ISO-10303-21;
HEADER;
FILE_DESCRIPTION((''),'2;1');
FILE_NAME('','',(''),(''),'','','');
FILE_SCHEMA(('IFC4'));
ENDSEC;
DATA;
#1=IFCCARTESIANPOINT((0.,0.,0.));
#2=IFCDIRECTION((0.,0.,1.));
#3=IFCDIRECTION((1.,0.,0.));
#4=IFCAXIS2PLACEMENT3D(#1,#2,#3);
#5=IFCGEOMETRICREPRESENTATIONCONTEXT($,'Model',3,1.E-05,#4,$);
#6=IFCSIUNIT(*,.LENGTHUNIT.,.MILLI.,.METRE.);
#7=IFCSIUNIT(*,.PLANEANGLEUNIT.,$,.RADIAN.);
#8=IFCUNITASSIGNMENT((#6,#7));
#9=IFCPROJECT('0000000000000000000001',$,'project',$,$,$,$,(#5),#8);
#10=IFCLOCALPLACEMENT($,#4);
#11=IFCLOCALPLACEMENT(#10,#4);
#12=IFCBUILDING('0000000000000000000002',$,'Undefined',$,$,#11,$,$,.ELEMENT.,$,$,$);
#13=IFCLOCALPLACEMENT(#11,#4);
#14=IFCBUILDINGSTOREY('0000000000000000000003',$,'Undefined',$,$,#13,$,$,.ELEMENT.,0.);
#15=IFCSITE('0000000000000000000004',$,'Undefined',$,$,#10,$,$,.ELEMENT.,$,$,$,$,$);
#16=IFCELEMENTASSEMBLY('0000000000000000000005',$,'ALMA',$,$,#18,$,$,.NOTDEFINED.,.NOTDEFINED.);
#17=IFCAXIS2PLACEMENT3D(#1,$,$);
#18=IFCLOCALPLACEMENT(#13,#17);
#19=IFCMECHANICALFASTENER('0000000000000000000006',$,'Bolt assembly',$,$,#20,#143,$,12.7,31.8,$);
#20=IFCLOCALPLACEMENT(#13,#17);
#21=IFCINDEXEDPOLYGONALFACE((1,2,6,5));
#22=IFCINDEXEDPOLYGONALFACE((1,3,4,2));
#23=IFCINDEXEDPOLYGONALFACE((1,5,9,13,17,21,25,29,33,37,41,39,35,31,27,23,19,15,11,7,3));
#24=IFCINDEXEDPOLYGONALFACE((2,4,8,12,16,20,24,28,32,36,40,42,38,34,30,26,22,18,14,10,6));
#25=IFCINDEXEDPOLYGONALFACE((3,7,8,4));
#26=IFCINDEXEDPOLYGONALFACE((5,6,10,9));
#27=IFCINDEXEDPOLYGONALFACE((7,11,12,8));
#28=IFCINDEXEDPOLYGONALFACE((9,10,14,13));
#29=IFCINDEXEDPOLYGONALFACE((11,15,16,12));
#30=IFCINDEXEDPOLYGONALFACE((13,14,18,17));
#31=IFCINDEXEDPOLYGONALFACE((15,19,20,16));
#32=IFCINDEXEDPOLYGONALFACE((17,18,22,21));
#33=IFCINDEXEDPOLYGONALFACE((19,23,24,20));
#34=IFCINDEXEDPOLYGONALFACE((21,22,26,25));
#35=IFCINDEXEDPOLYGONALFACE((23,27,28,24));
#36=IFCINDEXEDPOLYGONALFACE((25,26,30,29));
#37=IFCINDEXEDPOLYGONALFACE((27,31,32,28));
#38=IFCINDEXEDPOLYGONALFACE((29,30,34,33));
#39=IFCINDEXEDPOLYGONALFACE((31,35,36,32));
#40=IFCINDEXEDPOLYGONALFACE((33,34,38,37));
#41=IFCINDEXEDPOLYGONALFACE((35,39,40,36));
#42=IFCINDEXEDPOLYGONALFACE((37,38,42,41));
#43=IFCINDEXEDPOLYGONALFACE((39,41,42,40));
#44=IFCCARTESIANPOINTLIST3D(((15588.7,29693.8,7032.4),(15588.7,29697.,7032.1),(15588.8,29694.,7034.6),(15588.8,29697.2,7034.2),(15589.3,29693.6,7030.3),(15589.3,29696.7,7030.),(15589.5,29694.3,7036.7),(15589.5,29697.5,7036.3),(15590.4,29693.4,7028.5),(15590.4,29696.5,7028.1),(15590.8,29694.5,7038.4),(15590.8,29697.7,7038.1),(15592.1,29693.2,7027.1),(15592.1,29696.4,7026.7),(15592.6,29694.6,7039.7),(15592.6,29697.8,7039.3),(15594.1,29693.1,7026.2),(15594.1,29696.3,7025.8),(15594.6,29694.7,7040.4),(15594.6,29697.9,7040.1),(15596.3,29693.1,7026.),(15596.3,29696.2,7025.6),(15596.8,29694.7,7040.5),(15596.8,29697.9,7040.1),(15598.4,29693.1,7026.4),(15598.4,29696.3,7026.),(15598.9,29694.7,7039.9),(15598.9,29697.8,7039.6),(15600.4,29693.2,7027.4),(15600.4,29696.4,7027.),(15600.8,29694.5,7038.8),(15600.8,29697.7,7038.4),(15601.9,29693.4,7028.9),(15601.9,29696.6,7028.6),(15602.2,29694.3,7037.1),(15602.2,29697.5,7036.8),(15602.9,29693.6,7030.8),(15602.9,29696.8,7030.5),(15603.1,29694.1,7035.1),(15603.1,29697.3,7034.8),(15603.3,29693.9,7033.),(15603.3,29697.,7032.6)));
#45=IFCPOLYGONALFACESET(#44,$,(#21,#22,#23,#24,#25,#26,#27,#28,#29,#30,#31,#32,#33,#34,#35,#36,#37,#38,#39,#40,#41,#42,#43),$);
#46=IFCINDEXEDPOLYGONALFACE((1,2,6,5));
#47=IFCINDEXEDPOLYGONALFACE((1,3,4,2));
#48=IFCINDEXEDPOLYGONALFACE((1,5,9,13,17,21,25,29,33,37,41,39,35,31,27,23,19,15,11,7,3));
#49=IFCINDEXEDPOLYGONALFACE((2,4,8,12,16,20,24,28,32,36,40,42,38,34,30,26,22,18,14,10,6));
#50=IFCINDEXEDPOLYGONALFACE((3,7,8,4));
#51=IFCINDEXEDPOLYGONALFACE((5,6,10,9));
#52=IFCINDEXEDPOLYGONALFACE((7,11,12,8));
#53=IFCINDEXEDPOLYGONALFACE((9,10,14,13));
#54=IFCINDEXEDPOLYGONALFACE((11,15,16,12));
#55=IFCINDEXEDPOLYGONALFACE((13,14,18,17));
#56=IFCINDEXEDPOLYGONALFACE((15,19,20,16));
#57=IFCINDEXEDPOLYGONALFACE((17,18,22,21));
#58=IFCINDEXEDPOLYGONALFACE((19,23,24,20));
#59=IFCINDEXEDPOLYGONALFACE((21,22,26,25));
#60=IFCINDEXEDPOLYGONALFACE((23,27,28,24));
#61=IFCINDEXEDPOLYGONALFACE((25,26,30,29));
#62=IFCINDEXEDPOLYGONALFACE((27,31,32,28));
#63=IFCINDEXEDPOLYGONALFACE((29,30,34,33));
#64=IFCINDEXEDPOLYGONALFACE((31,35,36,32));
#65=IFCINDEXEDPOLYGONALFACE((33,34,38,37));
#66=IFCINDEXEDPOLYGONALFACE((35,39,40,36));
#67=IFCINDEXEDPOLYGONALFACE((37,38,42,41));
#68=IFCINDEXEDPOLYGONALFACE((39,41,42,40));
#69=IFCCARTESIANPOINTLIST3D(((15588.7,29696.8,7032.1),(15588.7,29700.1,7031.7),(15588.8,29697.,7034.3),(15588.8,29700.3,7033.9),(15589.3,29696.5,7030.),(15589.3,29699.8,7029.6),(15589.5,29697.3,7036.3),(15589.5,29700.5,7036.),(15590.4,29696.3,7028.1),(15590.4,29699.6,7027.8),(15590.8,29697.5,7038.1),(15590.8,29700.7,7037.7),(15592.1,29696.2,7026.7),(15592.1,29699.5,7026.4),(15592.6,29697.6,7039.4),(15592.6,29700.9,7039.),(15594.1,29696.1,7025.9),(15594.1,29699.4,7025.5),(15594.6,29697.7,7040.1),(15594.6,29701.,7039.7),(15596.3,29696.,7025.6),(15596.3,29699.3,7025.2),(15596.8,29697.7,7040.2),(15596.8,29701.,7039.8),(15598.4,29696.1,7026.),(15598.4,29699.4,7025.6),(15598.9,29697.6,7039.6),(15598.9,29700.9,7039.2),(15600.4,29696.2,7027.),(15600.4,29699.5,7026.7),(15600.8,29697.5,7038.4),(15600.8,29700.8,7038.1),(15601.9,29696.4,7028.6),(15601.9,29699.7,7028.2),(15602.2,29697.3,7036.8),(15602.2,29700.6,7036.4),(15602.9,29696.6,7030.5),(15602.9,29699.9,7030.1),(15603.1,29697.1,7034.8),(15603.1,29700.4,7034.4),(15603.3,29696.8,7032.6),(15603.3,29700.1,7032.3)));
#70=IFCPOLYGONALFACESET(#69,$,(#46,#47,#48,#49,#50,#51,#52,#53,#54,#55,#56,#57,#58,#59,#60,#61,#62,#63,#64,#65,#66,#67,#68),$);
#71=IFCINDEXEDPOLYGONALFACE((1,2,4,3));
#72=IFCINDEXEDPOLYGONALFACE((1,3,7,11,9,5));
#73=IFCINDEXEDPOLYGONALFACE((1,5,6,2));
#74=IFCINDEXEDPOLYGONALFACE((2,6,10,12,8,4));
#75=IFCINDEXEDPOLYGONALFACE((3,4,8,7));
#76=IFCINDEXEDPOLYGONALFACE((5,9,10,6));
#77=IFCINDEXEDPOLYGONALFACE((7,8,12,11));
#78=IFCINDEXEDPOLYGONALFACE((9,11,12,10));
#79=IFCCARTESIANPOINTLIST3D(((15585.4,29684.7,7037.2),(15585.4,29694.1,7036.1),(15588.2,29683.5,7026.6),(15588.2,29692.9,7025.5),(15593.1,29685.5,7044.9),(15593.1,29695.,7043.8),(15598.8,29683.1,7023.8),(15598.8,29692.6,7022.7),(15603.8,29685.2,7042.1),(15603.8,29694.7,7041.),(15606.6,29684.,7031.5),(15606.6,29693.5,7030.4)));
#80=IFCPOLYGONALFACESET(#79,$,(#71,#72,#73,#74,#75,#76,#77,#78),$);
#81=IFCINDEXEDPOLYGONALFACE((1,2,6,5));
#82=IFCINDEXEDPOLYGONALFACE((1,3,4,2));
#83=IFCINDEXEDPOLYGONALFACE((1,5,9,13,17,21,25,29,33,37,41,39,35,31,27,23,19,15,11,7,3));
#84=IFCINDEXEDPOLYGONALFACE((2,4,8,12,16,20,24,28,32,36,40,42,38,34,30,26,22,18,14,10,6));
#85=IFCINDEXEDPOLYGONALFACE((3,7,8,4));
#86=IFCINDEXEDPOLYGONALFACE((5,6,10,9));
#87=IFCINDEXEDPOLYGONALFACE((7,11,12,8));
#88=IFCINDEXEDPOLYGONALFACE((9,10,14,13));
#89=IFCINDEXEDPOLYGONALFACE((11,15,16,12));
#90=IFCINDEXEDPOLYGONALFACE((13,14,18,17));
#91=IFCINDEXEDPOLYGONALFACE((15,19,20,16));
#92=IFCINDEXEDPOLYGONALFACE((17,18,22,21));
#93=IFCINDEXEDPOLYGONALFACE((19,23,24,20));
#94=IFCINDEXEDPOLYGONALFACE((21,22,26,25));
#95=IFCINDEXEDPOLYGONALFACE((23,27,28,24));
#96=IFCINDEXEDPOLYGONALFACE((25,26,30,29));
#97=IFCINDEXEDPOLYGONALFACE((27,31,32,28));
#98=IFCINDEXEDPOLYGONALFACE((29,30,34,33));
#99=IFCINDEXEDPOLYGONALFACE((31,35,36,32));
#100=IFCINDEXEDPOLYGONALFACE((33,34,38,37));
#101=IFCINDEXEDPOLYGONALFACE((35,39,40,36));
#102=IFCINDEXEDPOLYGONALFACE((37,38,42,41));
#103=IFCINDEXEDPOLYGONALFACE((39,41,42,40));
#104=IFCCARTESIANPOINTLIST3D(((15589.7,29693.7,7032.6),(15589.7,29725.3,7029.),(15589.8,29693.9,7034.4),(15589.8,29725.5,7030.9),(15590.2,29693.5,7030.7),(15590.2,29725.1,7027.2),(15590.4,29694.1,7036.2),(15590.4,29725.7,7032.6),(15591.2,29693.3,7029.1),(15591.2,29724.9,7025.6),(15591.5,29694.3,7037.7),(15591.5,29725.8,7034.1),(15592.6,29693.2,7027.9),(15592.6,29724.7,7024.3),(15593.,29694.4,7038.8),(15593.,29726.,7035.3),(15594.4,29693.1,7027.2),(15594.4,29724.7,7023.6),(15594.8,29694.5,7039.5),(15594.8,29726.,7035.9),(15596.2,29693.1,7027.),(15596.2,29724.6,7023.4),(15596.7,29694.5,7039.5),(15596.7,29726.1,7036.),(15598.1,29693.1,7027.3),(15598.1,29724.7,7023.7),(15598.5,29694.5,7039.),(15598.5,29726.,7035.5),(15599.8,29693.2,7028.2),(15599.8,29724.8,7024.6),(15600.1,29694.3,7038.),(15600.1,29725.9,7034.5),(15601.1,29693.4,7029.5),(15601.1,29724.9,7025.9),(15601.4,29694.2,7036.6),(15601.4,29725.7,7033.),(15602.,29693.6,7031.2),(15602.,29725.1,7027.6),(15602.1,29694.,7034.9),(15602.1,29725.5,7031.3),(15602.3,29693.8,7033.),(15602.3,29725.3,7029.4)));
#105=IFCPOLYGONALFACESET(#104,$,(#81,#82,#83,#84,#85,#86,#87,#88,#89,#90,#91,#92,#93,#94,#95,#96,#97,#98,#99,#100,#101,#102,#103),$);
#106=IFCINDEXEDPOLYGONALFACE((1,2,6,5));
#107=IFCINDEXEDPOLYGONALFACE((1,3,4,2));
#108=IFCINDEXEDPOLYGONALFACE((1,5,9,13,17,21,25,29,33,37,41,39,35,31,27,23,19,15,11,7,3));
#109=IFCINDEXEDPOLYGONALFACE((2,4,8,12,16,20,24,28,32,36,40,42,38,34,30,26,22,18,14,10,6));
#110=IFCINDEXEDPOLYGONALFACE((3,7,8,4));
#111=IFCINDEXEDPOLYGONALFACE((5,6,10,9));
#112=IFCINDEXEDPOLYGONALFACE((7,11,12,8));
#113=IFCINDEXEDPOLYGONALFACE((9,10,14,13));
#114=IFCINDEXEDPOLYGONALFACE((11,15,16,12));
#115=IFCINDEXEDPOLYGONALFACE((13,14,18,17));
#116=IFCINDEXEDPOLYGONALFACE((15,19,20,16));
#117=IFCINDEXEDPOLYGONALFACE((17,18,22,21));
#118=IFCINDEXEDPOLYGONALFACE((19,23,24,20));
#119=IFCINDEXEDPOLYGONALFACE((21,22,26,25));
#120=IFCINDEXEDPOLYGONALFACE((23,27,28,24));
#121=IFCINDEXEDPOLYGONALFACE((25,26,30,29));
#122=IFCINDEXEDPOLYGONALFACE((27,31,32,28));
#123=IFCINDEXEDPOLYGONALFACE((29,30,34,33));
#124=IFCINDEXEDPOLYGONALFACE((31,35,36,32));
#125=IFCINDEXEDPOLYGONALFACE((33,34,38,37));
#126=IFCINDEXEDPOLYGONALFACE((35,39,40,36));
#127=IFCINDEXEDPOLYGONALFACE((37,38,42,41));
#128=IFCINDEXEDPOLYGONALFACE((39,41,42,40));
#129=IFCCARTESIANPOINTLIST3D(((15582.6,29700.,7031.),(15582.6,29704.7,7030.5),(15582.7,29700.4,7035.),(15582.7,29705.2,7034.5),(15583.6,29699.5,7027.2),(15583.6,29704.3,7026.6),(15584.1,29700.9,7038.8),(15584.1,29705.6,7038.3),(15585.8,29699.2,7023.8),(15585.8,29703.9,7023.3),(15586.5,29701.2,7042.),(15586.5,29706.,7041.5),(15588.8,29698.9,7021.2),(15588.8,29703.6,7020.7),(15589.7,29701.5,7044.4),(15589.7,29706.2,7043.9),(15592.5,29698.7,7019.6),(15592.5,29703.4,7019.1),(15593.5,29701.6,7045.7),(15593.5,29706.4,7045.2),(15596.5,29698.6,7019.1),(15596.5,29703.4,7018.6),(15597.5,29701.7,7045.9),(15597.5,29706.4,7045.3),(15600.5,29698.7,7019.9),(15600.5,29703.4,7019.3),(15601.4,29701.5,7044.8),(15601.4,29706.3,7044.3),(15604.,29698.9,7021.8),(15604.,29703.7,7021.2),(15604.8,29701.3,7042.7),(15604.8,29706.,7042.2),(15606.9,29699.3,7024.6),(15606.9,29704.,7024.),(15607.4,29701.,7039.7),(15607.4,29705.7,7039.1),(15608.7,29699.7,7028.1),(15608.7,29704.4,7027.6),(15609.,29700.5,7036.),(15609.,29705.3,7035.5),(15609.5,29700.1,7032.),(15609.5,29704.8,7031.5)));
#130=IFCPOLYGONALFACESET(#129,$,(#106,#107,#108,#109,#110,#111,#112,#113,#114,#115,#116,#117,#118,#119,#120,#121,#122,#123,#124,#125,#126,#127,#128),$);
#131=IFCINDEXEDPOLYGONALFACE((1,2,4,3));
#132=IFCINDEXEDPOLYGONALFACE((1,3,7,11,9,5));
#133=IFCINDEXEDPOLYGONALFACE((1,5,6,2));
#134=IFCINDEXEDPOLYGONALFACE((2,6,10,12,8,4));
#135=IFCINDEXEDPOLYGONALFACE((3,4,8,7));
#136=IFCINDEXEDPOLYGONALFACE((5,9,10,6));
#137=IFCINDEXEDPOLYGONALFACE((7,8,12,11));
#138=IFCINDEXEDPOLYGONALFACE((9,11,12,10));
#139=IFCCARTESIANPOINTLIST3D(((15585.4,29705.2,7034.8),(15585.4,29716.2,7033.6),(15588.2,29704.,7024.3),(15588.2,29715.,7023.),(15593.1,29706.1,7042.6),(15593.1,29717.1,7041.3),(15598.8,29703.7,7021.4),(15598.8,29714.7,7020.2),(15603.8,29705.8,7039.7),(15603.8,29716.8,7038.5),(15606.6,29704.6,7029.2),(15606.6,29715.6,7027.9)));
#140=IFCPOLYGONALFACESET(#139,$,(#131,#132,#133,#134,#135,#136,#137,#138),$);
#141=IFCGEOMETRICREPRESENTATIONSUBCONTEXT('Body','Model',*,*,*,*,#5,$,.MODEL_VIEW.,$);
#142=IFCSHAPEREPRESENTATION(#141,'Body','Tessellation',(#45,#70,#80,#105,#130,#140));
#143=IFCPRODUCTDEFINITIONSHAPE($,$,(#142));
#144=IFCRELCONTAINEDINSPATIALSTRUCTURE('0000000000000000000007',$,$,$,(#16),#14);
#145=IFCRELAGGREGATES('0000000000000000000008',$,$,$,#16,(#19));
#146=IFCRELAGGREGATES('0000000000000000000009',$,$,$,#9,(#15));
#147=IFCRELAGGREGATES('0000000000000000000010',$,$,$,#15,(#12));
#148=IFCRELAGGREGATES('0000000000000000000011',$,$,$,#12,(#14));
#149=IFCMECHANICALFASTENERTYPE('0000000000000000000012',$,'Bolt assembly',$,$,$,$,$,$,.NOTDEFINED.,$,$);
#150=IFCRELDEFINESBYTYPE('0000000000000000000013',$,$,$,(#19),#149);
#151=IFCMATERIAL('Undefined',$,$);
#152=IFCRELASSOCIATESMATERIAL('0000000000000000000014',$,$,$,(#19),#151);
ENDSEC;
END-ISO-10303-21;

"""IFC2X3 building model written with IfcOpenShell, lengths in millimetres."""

from ifc_helpers import new_model, si_unit, frame, origin_with_axes, origin_2d_with_axis, place, context, subcontext, project, spatial, polyline, circle, outline, extrude, source, transform, mapped, material, type_object, element, aggregate, save


model = new_model("IFC2X3")

# Units and contexts
model_context = context("Model", 3, precision=1e-05, world=origin_with_axes())
body_context = subcontext(model_context, "Body", "Model", "MODEL_VIEW")
ifc_project = project(units=[si_unit("LENGTHUNIT", "METRE", prefix="MILLI"), si_unit("PLANEANGLEUNIT", "RADIAN")], contexts=[model_context])

# Site, building, storey
site_placement = place(None, origin_with_axes())
site = spatial("IfcSite", under=ifc_project, at=site_placement, Name="Undefined", CompositionType="ELEMENT")
building_placement = place(site_placement, origin_with_axes())
building = spatial("IfcBuilding", under=site, at=building_placement, Name="Undefined", CompositionType="ELEMENT")
storey_placement = place(building_placement, origin_with_axes())
storey = spatial("IfcBuildingStorey", under=building, at=storey_placement, Name="Undefined", CompositionType="ELEMENT", Elevation=0.0)

# Element assembly
assembly_1_placement = place(storey_placement, origin_with_axes())
assembly_1 = element("IfcElementAssembly", 1, at=assembly_1_placement, inside=storey, Name="ALMA", AssemblyPlace="NOTDEFINED", PredefinedType="NOTDEFINED")

# Shared definitions
ifc_material_1 = material(Name="Undefined")
mechanical_fastener_type = type_object("IfcMechanicalFastenerType", Name="Bolt assembly")

# Mechanical fastener
shared_shape_1 = source(origin_with_axes(), body_context, "Body", "SweptSolid", [
    extrude(circle(Radius=7.3, at=origin_2d_with_axis()), frame((0.0, 0.1, 0.0), z_axis=(0.0, 1.0, 0.0), x_axis=(1.0, 0.0, 0.0)), (0.0, 0.0, 1.0), 3.2),
    extrude(circle(Radius=7.3, at=origin_2d_with_axis()), frame((0.0, 3.1, 0.0), z_axis=(0.0, 1.0, 0.0), x_axis=(1.0, 0.0, 0.0)), (0.0, 0.0, 1.0), 3.3),
    extrude(outline(polyline([(9.5, -5.5), (9.5, 5.5), (0.0, 11.0), (-9.5, 5.5), (-9.5, -5.5), (0.0, -11.0), (9.5, -5.5)])), frame((0.0, -9.5, 0.0), z_axis=(0.0, 1.0, 0.0), x_axis=(1.0, 0.0, 0.0)), (0.0, 0.0, 1.0), 9.5),
    extrude(circle(Radius=6.3, at=origin_2d_with_axis()), frame((0.0, 0.0, 0.0), z_axis=(0.0, 1.0, 0.0), x_axis=(1.0, 0.0, 0.0)), (0.0, 0.0, 1.0), 31.8),
    extrude(circle(Radius=13.5, at=origin_2d_with_axis()), frame((0.0, 6.4, 0.0), z_axis=(0.0, 1.0, 0.0), x_axis=(1.0, 0.0, 0.0)), (0.0, 0.0, 1.0), 4.8),
    extrude(outline(polyline([(9.5, -5.5), (9.5, 5.5), (0.0, 11.0), (-9.5, 5.5), (-9.5, -5.5), (0.0, -11.0), (9.5, -5.5)])), frame((0.0, 11.2, 0.0), z_axis=(0.0, 1.0, 0.0), x_axis=(1.0, 0.0, 0.0)), (0.0, 0.0, 1.0), 11.1),
])
mechanical_fastener_1_placement = place(assembly_1_placement, frame((15596.0, 29693.8, 7033.3), z_axis=(-0.707107, -0.079651, -0.702606), x_axis=(-0.707107, 0.079651, 0.702606)))
mechanical_fastener_1 = element("IfcMechanicalFastener", 2, at=mechanical_fastener_1_placement, type_object=mechanical_fastener_type, material=ifc_material_1, Name="Bolt assembly", NominalDiameter=12.7, NominalLength=31.8, context=body_context, shape_type="MappedRepresentation", body=[
    mapped(shared_shape_1, transform((0.0, 0.0, 0.0))),
])
aggregate(assembly_1, [mechanical_fastener_1])

save(model, "model.ifc")
